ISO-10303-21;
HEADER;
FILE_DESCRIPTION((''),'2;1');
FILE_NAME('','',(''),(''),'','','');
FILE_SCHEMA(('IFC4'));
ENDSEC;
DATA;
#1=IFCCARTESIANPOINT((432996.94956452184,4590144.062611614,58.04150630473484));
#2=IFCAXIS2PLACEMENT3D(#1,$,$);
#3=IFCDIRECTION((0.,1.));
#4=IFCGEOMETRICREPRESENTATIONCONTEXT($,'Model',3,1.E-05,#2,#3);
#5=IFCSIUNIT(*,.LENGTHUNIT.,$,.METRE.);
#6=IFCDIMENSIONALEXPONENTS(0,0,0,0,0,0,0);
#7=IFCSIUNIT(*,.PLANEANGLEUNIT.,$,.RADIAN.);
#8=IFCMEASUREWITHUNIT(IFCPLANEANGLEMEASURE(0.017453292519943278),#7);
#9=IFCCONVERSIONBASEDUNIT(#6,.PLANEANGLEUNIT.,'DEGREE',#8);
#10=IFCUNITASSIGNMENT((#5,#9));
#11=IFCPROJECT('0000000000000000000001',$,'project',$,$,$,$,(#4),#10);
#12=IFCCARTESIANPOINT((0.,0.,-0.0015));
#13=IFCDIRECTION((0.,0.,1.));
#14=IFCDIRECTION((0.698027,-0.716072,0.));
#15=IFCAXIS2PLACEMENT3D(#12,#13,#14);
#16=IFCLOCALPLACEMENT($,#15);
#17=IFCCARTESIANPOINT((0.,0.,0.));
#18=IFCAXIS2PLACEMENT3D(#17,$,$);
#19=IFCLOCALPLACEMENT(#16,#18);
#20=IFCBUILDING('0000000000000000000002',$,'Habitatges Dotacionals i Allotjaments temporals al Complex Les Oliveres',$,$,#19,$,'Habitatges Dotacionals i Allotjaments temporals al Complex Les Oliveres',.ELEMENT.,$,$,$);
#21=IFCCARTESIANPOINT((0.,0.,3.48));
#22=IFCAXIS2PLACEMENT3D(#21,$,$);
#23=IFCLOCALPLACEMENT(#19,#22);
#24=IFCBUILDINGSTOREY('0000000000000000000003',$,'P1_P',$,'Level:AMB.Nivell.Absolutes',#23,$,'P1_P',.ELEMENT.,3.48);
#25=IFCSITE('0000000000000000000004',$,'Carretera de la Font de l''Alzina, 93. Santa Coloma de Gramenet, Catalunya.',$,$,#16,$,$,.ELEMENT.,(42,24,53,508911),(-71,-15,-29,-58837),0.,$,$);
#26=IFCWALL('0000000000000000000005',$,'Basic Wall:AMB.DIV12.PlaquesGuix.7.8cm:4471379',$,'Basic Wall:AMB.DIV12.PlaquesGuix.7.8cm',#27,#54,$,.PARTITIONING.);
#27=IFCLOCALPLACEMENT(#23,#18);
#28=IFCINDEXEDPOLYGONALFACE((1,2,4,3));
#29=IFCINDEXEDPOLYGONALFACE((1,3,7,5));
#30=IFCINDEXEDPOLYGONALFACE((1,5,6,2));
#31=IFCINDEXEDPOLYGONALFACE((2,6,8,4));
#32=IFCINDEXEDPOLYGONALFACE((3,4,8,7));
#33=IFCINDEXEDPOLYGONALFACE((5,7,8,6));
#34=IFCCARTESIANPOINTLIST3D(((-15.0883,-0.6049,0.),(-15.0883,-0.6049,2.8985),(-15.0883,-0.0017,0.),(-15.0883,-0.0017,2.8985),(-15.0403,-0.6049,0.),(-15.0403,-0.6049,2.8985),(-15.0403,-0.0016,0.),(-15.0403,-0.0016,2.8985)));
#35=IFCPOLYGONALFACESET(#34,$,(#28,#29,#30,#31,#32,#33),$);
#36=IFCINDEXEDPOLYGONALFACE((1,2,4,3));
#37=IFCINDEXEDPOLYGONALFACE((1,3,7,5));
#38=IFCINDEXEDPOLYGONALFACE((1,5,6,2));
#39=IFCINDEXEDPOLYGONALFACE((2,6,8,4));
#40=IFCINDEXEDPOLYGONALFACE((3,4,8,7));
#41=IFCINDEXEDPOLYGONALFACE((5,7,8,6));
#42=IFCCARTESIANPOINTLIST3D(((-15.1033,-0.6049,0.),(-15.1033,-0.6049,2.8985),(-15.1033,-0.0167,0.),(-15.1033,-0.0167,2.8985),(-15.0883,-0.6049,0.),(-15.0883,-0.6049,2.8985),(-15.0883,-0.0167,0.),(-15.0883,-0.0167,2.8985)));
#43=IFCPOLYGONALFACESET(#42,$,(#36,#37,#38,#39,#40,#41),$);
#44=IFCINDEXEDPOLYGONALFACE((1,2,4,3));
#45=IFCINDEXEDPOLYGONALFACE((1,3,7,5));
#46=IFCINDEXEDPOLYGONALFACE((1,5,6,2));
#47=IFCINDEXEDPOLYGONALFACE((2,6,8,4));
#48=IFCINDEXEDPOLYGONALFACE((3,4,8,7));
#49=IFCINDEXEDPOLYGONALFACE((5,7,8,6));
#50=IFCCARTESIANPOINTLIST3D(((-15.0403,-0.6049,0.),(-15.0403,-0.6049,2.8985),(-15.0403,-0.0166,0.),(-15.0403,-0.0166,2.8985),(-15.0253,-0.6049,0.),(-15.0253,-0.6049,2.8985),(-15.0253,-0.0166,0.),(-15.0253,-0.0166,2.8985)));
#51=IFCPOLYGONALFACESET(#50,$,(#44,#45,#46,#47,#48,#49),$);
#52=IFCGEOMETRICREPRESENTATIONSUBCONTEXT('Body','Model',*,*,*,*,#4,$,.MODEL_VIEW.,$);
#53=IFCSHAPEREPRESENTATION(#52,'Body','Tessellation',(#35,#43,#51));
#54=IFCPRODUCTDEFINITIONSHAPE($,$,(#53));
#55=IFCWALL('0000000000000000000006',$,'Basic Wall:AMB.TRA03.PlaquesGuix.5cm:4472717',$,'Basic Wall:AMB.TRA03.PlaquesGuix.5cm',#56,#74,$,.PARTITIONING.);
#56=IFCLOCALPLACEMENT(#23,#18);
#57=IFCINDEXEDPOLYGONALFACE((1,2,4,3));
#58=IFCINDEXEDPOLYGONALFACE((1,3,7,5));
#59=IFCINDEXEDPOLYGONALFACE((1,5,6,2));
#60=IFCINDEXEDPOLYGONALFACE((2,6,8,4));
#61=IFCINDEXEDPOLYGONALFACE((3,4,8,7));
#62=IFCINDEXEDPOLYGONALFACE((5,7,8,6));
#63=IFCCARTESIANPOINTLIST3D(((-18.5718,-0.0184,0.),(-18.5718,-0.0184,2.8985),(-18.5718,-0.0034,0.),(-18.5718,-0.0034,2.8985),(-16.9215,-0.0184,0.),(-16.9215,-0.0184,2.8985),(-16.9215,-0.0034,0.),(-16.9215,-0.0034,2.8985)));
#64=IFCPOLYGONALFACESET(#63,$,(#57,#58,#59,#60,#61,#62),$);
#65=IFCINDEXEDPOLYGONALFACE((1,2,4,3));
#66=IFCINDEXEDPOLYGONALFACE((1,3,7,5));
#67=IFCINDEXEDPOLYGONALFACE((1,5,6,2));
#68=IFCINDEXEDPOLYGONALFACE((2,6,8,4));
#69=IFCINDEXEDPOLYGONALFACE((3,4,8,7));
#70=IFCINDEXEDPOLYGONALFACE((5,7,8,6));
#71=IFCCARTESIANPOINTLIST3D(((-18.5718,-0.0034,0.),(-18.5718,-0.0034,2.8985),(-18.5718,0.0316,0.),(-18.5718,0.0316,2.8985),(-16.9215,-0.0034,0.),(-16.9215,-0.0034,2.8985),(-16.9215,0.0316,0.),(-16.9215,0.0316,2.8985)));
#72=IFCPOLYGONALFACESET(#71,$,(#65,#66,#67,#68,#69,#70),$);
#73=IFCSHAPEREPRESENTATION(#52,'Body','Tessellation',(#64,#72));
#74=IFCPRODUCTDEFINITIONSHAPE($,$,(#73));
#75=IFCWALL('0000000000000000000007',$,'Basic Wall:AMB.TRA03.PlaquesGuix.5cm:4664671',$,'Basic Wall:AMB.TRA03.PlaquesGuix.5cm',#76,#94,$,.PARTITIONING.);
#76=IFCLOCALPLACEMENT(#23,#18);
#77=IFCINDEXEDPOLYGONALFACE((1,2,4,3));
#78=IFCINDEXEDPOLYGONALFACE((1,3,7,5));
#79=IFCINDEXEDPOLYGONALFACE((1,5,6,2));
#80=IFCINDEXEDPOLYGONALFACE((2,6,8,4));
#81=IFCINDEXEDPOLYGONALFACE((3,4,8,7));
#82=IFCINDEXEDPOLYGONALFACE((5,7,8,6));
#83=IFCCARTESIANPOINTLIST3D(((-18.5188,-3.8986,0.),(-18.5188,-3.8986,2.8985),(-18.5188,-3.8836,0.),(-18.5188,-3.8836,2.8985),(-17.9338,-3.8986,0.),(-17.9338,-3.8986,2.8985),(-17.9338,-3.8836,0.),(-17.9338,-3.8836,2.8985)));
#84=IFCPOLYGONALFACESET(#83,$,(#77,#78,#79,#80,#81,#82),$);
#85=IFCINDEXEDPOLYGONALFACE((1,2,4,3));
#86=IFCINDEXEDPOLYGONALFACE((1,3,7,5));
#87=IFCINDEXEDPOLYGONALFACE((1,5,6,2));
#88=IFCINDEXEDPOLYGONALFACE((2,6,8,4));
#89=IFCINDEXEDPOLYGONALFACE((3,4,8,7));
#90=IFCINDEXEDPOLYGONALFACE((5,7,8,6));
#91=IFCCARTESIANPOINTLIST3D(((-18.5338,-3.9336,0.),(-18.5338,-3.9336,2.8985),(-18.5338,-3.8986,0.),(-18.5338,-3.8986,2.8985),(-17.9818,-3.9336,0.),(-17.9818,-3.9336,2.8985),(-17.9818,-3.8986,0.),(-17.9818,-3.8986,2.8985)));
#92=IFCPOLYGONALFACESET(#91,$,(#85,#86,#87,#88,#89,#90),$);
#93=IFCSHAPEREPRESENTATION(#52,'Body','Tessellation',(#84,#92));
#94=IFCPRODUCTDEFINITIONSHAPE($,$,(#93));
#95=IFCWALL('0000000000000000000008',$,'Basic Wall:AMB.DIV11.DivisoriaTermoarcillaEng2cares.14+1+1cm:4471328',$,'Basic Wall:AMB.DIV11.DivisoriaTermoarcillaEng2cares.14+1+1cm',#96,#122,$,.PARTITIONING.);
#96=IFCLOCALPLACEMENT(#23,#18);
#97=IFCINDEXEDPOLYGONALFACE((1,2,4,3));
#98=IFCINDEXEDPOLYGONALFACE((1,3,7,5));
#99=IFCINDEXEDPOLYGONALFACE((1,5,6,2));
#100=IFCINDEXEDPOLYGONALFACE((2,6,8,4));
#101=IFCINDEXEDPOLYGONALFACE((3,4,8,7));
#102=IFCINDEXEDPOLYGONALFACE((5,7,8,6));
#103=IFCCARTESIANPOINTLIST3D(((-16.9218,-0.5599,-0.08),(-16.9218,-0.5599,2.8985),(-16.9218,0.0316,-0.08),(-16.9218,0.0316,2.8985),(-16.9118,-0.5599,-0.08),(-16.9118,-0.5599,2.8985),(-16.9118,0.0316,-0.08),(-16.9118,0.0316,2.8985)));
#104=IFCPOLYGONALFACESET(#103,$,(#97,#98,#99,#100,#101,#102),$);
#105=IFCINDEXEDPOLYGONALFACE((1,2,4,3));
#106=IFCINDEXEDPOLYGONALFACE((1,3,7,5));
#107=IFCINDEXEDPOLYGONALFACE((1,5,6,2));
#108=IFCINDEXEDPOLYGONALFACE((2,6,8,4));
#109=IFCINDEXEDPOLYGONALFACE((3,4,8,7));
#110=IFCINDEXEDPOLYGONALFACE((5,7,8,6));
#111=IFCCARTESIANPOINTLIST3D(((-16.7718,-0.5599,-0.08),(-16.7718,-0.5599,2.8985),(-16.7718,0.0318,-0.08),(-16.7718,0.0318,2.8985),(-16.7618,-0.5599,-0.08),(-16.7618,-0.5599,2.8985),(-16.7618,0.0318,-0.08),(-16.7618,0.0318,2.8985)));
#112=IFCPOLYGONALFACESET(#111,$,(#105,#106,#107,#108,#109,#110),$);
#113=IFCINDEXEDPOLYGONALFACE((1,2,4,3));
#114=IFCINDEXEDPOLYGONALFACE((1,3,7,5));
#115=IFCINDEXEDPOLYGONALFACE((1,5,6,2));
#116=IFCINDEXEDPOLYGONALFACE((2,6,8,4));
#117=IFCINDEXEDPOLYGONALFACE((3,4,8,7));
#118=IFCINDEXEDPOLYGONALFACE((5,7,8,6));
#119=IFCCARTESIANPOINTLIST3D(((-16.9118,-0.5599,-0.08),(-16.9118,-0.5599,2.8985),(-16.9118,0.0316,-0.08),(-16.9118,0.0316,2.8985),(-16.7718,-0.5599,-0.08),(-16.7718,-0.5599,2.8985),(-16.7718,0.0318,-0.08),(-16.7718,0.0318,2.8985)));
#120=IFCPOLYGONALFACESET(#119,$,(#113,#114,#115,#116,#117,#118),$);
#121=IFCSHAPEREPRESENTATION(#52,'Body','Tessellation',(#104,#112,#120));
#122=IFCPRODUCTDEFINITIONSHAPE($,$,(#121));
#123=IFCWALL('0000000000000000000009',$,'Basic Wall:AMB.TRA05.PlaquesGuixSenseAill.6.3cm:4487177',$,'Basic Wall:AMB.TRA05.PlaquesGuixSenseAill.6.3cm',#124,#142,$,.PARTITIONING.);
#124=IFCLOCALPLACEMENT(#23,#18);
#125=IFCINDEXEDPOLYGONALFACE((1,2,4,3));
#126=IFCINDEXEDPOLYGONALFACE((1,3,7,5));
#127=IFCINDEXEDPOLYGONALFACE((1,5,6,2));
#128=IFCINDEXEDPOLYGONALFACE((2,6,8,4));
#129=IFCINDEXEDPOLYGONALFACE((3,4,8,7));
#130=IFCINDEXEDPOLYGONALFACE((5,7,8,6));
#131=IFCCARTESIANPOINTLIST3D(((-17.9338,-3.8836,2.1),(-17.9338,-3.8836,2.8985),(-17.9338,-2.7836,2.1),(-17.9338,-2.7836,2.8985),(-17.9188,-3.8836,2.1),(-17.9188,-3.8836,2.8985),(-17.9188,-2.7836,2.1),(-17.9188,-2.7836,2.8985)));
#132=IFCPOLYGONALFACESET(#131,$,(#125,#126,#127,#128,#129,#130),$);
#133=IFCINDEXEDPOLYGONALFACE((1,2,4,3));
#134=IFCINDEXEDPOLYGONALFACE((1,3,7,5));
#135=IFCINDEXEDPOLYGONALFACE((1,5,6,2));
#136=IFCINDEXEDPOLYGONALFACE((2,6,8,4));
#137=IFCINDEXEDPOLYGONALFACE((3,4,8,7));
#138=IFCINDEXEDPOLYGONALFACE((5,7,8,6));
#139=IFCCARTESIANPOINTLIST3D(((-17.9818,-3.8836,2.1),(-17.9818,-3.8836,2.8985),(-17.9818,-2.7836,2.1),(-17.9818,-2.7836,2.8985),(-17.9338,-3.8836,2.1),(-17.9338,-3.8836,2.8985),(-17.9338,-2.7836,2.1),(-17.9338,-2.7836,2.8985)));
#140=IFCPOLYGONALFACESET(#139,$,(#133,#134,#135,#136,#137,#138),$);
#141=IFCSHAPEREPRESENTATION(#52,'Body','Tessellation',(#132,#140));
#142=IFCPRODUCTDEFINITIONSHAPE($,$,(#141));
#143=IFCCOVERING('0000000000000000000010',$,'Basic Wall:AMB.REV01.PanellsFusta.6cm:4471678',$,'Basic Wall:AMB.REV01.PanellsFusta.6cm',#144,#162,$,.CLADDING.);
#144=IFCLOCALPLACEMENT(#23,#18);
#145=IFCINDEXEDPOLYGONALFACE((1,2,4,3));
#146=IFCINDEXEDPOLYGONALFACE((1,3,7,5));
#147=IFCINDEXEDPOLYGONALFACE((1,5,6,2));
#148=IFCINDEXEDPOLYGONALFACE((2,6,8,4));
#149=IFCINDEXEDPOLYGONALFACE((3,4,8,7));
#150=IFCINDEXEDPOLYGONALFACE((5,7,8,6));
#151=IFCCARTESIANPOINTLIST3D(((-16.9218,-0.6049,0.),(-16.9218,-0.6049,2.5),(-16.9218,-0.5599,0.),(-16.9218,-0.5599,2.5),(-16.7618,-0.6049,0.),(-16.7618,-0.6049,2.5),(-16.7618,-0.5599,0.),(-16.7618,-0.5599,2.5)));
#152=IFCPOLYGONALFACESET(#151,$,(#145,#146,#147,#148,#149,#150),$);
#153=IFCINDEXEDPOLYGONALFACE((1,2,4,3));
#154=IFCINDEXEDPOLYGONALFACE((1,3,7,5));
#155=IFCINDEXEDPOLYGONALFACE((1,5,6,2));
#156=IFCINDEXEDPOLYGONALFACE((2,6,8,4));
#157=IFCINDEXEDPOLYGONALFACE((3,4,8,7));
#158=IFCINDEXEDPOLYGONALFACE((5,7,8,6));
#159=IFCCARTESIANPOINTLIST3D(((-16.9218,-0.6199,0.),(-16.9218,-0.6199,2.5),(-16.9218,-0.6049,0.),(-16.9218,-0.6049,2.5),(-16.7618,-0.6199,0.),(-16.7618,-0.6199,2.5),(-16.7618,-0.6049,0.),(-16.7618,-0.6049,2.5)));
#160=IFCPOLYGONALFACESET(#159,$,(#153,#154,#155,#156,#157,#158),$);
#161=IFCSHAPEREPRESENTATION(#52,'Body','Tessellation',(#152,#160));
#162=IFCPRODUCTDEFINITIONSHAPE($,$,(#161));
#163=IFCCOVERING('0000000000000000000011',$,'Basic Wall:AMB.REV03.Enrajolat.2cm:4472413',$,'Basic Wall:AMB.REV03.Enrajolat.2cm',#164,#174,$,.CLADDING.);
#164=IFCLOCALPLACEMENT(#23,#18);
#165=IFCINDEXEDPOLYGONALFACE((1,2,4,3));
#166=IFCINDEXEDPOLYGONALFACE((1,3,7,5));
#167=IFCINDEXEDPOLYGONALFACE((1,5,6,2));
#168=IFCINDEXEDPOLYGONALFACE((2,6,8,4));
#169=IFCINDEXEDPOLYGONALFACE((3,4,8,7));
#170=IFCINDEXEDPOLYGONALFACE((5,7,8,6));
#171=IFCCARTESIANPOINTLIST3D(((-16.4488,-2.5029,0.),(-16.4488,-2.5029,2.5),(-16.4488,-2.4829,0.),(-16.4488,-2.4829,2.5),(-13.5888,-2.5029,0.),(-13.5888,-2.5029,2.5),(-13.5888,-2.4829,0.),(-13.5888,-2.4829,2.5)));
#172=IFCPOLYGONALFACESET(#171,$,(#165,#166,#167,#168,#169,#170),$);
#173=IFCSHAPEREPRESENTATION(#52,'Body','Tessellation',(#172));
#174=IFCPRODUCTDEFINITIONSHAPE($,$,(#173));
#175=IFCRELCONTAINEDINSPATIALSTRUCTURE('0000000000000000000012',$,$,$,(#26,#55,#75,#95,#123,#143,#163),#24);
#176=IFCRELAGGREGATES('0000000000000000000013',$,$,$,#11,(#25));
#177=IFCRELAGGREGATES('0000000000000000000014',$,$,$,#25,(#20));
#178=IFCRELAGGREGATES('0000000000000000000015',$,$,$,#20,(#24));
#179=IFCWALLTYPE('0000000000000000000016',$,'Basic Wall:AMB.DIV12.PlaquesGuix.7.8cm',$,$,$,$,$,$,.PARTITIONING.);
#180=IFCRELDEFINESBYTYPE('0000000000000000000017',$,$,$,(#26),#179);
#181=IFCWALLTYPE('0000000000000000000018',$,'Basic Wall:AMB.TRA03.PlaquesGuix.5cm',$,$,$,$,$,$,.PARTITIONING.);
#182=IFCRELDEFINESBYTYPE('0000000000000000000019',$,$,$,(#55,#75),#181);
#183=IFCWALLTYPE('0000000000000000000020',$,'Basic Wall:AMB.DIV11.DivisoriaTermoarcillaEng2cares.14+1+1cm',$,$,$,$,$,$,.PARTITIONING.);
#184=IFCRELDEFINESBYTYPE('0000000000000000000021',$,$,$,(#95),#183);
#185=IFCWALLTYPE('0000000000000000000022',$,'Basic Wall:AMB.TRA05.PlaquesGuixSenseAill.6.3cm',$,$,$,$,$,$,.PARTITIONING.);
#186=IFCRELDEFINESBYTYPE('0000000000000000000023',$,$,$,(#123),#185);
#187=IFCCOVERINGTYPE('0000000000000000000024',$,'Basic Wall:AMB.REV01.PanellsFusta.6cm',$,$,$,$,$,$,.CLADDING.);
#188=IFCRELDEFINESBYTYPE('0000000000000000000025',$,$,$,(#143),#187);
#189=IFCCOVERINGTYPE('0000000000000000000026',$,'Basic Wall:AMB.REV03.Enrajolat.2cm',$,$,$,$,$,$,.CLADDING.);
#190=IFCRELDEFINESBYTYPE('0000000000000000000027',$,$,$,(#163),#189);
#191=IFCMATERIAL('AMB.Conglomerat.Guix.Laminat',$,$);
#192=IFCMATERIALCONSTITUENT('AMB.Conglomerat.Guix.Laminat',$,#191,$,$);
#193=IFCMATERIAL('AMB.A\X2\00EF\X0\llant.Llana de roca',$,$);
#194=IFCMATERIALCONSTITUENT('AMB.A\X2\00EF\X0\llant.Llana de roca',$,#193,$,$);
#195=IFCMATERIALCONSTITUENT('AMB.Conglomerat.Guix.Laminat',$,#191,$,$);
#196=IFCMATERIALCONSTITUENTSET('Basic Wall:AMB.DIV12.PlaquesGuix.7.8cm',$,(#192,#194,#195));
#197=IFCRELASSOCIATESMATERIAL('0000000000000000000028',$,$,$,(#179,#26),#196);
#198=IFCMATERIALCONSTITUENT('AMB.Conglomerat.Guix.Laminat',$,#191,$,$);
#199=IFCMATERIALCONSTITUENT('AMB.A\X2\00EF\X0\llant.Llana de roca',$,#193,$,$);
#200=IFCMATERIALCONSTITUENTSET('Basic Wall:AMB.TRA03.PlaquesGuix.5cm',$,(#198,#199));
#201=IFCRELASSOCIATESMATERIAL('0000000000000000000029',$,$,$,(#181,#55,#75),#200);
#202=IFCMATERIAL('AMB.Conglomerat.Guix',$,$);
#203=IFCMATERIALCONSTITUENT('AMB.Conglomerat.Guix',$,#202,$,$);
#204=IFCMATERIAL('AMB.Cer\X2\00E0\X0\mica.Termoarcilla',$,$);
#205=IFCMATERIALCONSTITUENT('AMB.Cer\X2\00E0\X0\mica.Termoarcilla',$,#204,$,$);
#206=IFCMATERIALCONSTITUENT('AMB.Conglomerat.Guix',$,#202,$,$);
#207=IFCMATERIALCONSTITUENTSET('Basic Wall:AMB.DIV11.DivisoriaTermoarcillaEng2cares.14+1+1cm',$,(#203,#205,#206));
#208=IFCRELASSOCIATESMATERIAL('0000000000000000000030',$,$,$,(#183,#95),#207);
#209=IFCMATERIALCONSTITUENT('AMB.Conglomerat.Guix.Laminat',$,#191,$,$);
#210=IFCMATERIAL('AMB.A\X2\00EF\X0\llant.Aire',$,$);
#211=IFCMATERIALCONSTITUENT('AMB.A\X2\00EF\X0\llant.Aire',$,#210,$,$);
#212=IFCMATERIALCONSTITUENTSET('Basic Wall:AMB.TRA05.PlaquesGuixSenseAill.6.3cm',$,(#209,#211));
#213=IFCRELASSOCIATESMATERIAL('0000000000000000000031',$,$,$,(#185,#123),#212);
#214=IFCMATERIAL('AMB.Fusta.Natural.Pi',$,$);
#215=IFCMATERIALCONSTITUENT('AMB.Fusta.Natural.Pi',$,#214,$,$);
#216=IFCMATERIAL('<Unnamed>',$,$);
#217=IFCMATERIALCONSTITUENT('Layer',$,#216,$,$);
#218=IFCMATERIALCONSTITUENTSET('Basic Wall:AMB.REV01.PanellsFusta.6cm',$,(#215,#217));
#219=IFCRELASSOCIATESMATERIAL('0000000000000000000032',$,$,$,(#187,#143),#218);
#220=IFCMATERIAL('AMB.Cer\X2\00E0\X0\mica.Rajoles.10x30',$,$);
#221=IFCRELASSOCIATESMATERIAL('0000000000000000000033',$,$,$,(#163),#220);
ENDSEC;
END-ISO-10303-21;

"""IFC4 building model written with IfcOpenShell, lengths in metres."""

from ifc_helpers import new_model, entity, si_unit, converted_unit, direction, frame, origin, place, context, subcontext, project, spatial, indexed_curve, outline, extrude, material, constituent, constituent_set, type_object, element, save


model = new_model("IFC4")

# Units and contexts
model_context = context("Model", 3, precision=1e-05, world=frame((432996.94956452184, 4590144.062611614, 58.04150630473484)), true_north=direction((0.0, 1.0)))
body_context = subcontext(model_context, "Body", "Model", "MODEL_VIEW")
ifc_project = project(units=[si_unit("LENGTHUNIT", "METRE"), converted_unit("PLANEANGLEUNIT", "DEGREE", entity("IfcPlaneAngleMeasure", 0.017453292519943278), si_unit("PLANEANGLEUNIT", "RADIAN"), dimensions=[0, 0, 0, 0, 0, 0, 0])], contexts=[model_context])

# Site, building, storey
site_placement = place(None, frame((0.0, 0.0, -0.0015), z_axis=(0.0, 0.0, 1.0), x_axis=(0.698027, -0.716072, 0.0)))
site = spatial("IfcSite", under=ifc_project, at=site_placement, Name="Carretera de la Font de l'Alzina, 93. Santa Coloma de Gramenet, Catalunya.", CompositionType="ELEMENT", RefLatitude=(42, 24, 53, 508911), RefLongitude=(-71, -15, -29, -58837), RefElevation=0.0)
building_placement = place(site_placement, origin())
building = spatial("IfcBuilding", under=site, at=building_placement, Name="Habitatges Dotacionals i Allotjaments temporals al Complex Les Oliveres", LongName="Habitatges Dotacionals i Allotjaments temporals al Complex Les Oliveres", CompositionType="ELEMENT")
storey_placement = place(building_placement, frame((0.0, 0.0, 3.48)))
storey = spatial("IfcBuildingStorey", under=building, at=storey_placement, Name="P1_P", ObjectType="Level:AMB.Nivell.Absolutes", LongName="P1_P", CompositionType="ELEMENT", Elevation=3.48)

# Shared definitions
ifc_material_1 = material(Name="AMB.Fusta.Natural.Pi")

# Shared definitions
ifc_material_2 = material(Name="AMB.Ceràmica.Termoarcilla")
ifc_material_3 = material(Name="AMB.Conglomerat.Guix")

# Shared definitions
ifc_material_4 = material(Name="AMB.Conglomerat.Guix.Laminat")
ifc_material_5 = material(Name="AMB.Aïllant.Llana de roca")

# Walls
ifc_constituent_1 = constituent(ifc_material_4, Name="AMB.Conglomerat.Guix.Laminat")
ifc_constituent_2 = constituent(ifc_material_5, Name="AMB.Aïllant.Llana de roca")
ifc_constituent_3 = constituent(ifc_material_4, Name="AMB.Conglomerat.Guix.Laminat")
ifc_constituent_set_1 = constituent_set(constituents=[ifc_constituent_1, ifc_constituent_2, ifc_constituent_3], Name="Basic Wall:AMB.DIV12.PlaquesGuix.7.8cm")
wall_type_1 = type_object("IfcWallType", Name="Basic Wall:AMB.DIV12.PlaquesGuix.7.8cm", PredefinedType="PARTITIONING", material=ifc_constituent_set_1)
wall_1_placement = place(storey_placement, frame((-15.0643, -0.6049, 0.0), z_axis=(0.0, 0.0, 1.0), x_axis=(0.0, 1.0, 0.0)))
element("IfcWall", 1, at=wall_1_placement, inside=storey, type_object=wall_type_1, material=ifc_constituent_set_1, Name="Basic Wall:AMB.DIV12.PlaquesGuix.7.8cm:4471379", ObjectType="Basic Wall:AMB.DIV12.PlaquesGuix.7.8cm", PredefinedType="PARTITIONING", context=body_context, shape_type="SweptSolid", body=[
    extrude(outline(indexed_curve([(-0.3016, -0.024), (0.3016, -0.024), (0.3016, 0.024), (-0.3016, 0.024), (-0.3016, -0.024)], self_intersect=False)), frame((0.3016, 0.0, 0.0)), (0.0, 0.0, 1.0), 2.8985),
    extrude(outline(indexed_curve([(-0.0075, -0.2941), (0.0075, -0.2941), (0.0075, 0.2941), (-0.0075, 0.2941), (-0.0075, -0.2941)], self_intersect=False)), frame((0.2941, 0.0315, 0.0), z_axis=(0.0, 0.0, 1.0), x_axis=(0.0, -1.0, 0.0)), (0.0, 0.0, 1.0), 2.8985),
    extrude(outline(indexed_curve([(-0.0078, -0.2941), (0.0072, -0.2941), (0.0078, 0.2941), (-0.0072, 0.2941), (-0.0078, -0.2941)], self_intersect=False)), frame((0.2941, -0.0315, 0.0), z_axis=(0.0, 0.0, 1.0), x_axis=(-0.000932, 1.0, 0.0)), (0.0, 0.0, 1.0), 2.8985),
])
ifc_constituent_4 = constituent(ifc_material_4, Name="AMB.Conglomerat.Guix.Laminat")
ifc_constituent_5 = constituent(ifc_material_5, Name="AMB.Aïllant.Llana de roca")
ifc_constituent_set_2 = constituent_set(constituents=[ifc_constituent_4, ifc_constituent_5], Name="Basic Wall:AMB.TRA03.PlaquesGuix.5cm")
wall_type_2 = type_object("IfcWallType", Name="Basic Wall:AMB.TRA03.PlaquesGuix.5cm", PredefinedType="PARTITIONING", material=ifc_constituent_set_2)
wall_2_placement = place(storey_placement, frame((-16.9215, 0.0066, 0.0), z_axis=(0.0, 0.0, 1.0), x_axis=(-1.0, 0.0, 0.0)))
element("IfcWall", 2, at=wall_2_placement, inside=storey, type_object=wall_type_2, material=ifc_constituent_set_2, Name="Basic Wall:AMB.TRA03.PlaquesGuix.5cm:4472717", ObjectType="Basic Wall:AMB.TRA03.PlaquesGuix.5cm", PredefinedType="PARTITIONING", context=body_context, shape_type="SweptSolid", body=[
    extrude(outline(indexed_curve([(-0.0075, -0.8251), (0.0075, -0.8251), (0.0075, 0.8251), (-0.0075, 0.8251), (-0.0075, -0.8251)], self_intersect=False)), frame((0.8251, 0.0175, 0.0), z_axis=(0.0, 0.0, 1.0), x_axis=(0.0, -1.0, 0.0)), (0.0, 0.0, 1.0), 2.8985),
    extrude(outline(indexed_curve([(-0.0175, -0.8251), (0.0175, -0.8251), (0.0175, 0.8251), (-0.0175, 0.8251), (-0.0175, -0.8251)], self_intersect=False)), frame((0.8251, -0.0075, 0.0), z_axis=(0.0, 0.0, 1.0), x_axis=(0.0, 1.0, 0.0)), (0.0, 0.0, 1.0), 2.8985),
])
wall_3_placement = place(storey_placement, frame((-17.9818, -3.9086, 0.0), z_axis=(0.0, 0.0, 1.0), x_axis=(-1.0, 0.0, 0.0)))
element("IfcWall", 3, at=wall_3_placement, inside=storey, type_object=wall_type_2, material=ifc_constituent_set_2, Name="Basic Wall:AMB.TRA03.PlaquesGuix.5cm:4664671", ObjectType="Basic Wall:AMB.TRA03.PlaquesGuix.5cm", PredefinedType="PARTITIONING", context=body_context, shape_type="SweptSolid", body=[
    extrude(outline(indexed_curve([(-0.0075, -0.2925), (0.0075, -0.2925), (0.0075, 0.2925), (-0.0075, 0.2925), (-0.0075, -0.2925)], self_intersect=False)), frame((0.2445, -0.0175, 0.0), z_axis=(0.0, 0.0, 1.0), x_axis=(0.0, 1.0, 0.0)), (0.0, 0.0, 1.0), 2.8985),
    extrude(outline(indexed_curve([(-0.0175, -0.276), (0.0175, -0.276), (0.0175, 0.276), (-0.0175, 0.276), (-0.0175, -0.276)], self_intersect=False)), frame((0.276, 0.0075, 0.0), z_axis=(0.0, 0.0, 1.0), x_axis=(0.0, -1.0, 0.0)), (0.0, 0.0, 1.0), 2.8985),
])
ifc_constituent_6 = constituent(ifc_material_3, Name="AMB.Conglomerat.Guix")
ifc_constituent_7 = constituent(ifc_material_2, Name="AMB.Ceràmica.Termoarcilla")
ifc_constituent_8 = constituent(ifc_material_3, Name="AMB.Conglomerat.Guix")
ifc_constituent_set_3 = constituent_set(constituents=[ifc_constituent_6, ifc_constituent_7, ifc_constituent_8], Name="Basic Wall:AMB.DIV11.DivisoriaTermoarcillaEng2cares.14+1+1cm")
wall_type_3 = type_object("IfcWallType", Name="Basic Wall:AMB.DIV11.DivisoriaTermoarcillaEng2cares.14+1+1cm", PredefinedType="PARTITIONING", material=ifc_constituent_set_3)
wall_4_placement = place(storey_placement, frame((-16.8418, 0.0318, -0.08), z_axis=(0.0, 0.0, 1.0), x_axis=(0.0, -1.0, 0.0)))
element("IfcWall", 4, at=wall_4_placement, inside=storey, type_object=wall_type_3, material=ifc_constituent_set_3, Name="Basic Wall:AMB.DIV11.DivisoriaTermoarcillaEng2cares.14+1+1cm:4471328", ObjectType="Basic Wall:AMB.DIV11.DivisoriaTermoarcillaEng2cares.14+1+1cm", PredefinedType="PARTITIONING", context=body_context, shape_type="SweptSolid", body=[
    extrude(outline(indexed_curve([(-0.005, -0.2958), (0.005, -0.2958), (0.005, 0.2958), (-0.005, 0.2958), (-0.005, -0.2958)], self_intersect=False)), frame((0.2959, -0.075, 0.0), z_axis=(0.0, 0.0, 1.0), x_axis=(0.0, 1.0, 0.0)), (0.0, 0.0, 1.0), 2.9785),
    extrude(outline(indexed_curve([(-0.0053, -0.2958), (0.0047, -0.2958), (0.0053, 0.2958), (-0.0047, 0.2958), (-0.0053, -0.2958)], self_intersect=False)), frame((0.2958, 0.075, 0.0), z_axis=(0.0, 0.0, 1.0), x_axis=(0.000932, -1.0, 0.0)), (0.0, 0.0, 1.0), 2.9785),
    extrude(outline(indexed_curve([(-0.2957, -0.07), (0.2958, -0.07), (0.2958, 0.07), (-0.2959, 0.07), (-0.2957, -0.07)], self_intersect=False)), frame((0.2959, 0.0, 0.0)), (0.0, 0.0, 1.0), 2.9785),
])
ifc_constituent_9 = constituent(ifc_material_4, Name="AMB.Conglomerat.Guix.Laminat")
ifc_material_6 = material(Name="AMB.Aïllant.Aire")
ifc_constituent_10 = constituent(ifc_material_6, Name="AMB.Aïllant.Aire")
ifc_constituent_set_4 = constituent_set(constituents=[ifc_constituent_9, ifc_constituent_10], Name="Basic Wall:AMB.TRA05.PlaquesGuixSenseAill.6.3cm")
wall_type_4 = type_object("IfcWallType", Name="Basic Wall:AMB.TRA05.PlaquesGuixSenseAill.6.3cm", PredefinedType="PARTITIONING", material=ifc_constituent_set_4)
wall_5_placement = place(storey_placement, frame((-17.9503, -2.7836, 2.1), z_axis=(0.0, 0.0, 1.0), x_axis=(0.0, -1.0, 0.0)))
element("IfcWall", 5, at=wall_5_placement, inside=storey, type_object=wall_type_4, material=ifc_constituent_set_4, Name="Basic Wall:AMB.TRA05.PlaquesGuixSenseAill.6.3cm:4487177", ObjectType="Basic Wall:AMB.TRA05.PlaquesGuixSenseAill.6.3cm", PredefinedType="PARTITIONING", context=body_context, shape_type="SweptSolid", body=[
    extrude(outline(indexed_curve([(-0.0075, -0.55), (0.0075, -0.55), (0.0075, 0.55), (-0.0075, 0.55), (-0.0075, -0.55)], self_intersect=False)), frame((0.55, 0.024, 0.0), z_axis=(0.0, 0.0, 1.0), x_axis=(0.0, -1.0, 0.0)), (0.0, 0.0, 1.0), 0.7985),
    extrude(outline(indexed_curve([(-0.024, -0.55), (0.024, -0.55), (0.024, 0.55), (-0.024, 0.55), (-0.024, -0.55)], self_intersect=False)), frame((0.55, -0.0075, 0.0), z_axis=(0.0, 0.0, 1.0), x_axis=(0.0, 1.0, 0.0)), (0.0, 0.0, 1.0), 0.7985),
])

# Coverings
ifc_constituent_11 = constituent(ifc_material_1, Name="AMB.Fusta.Natural.Pi")
ifc_material_7 = material(Name="<Unnamed>")
ifc_constituent_12 = constituent(ifc_material_7, Name="Layer")
ifc_constituent_set_5 = constituent_set(constituents=[ifc_constituent_11, ifc_constituent_12], Name="Basic Wall:AMB.REV01.PanellsFusta.6cm")
covering_type_1 = type_object("IfcCoveringType", Name="Basic Wall:AMB.REV01.PanellsFusta.6cm", PredefinedType="CLADDING", material=ifc_constituent_set_5)
covering_1_placement = place(storey_placement, frame((-16.9218, -0.5899, 0.0)))
element("IfcCovering", 6, at=covering_1_placement, inside=storey, type_object=covering_type_1, material=ifc_constituent_set_5, Name="Basic Wall:AMB.REV01.PanellsFusta.6cm:4471678", ObjectType="Basic Wall:AMB.REV01.PanellsFusta.6cm", PredefinedType="CLADDING", context=body_context, shape_type="SweptSolid", body=[
    extrude(outline(indexed_curve([(-0.0225, -0.08), (0.0225, -0.08), (0.0225, 0.08), (-0.0225, 0.08), (-0.0225, -0.08)], self_intersect=False)), frame((0.08, 0.0075, 0.0), z_axis=(0.0, 0.0, 1.0), x_axis=(0.0, -1.0, 0.0)), (0.0, 0.0, 1.0), 2.5),
    extrude(outline(indexed_curve([(-0.0075, -0.08), (0.0075, -0.08), (0.0075, 0.08), (-0.0075, 0.08), (-0.0075, -0.08)], self_intersect=False)), frame((0.08, -0.0225, 0.0), z_axis=(0.0, 0.0, 1.0), x_axis=(0.0, 1.0, 0.0)), (0.0, 0.0, 1.0), 2.5),
])
ifc_material_8 = material(Name="AMB.Ceràmica.Rajoles.10x30")
covering_type_2 = type_object("IfcCoveringType", Name="Basic Wall:AMB.REV03.Enrajolat.2cm", PredefinedType="CLADDING")
covering_2_placement = place(storey_placement, frame((-16.4488, -2.4929, 0.0)))
element("IfcCovering", 7, at=covering_2_placement, inside=storey, type_object=covering_type_2, material=ifc_material_8, Name="Basic Wall:AMB.REV03.Enrajolat.2cm:4472413", ObjectType="Basic Wall:AMB.REV03.Enrajolat.2cm", PredefinedType="CLADDING", context=body_context, shape_type="SweptSolid", body=[
    extrude(outline(indexed_curve([(2.86, 0.01), (0.0, 0.01), (0.0, -0.01), (2.86, -0.01), (2.86, 0.01)], self_intersect=False)), origin(), (0.0, 0.0, 1.0), 2.5),
])

save(model, "model.ifc")
